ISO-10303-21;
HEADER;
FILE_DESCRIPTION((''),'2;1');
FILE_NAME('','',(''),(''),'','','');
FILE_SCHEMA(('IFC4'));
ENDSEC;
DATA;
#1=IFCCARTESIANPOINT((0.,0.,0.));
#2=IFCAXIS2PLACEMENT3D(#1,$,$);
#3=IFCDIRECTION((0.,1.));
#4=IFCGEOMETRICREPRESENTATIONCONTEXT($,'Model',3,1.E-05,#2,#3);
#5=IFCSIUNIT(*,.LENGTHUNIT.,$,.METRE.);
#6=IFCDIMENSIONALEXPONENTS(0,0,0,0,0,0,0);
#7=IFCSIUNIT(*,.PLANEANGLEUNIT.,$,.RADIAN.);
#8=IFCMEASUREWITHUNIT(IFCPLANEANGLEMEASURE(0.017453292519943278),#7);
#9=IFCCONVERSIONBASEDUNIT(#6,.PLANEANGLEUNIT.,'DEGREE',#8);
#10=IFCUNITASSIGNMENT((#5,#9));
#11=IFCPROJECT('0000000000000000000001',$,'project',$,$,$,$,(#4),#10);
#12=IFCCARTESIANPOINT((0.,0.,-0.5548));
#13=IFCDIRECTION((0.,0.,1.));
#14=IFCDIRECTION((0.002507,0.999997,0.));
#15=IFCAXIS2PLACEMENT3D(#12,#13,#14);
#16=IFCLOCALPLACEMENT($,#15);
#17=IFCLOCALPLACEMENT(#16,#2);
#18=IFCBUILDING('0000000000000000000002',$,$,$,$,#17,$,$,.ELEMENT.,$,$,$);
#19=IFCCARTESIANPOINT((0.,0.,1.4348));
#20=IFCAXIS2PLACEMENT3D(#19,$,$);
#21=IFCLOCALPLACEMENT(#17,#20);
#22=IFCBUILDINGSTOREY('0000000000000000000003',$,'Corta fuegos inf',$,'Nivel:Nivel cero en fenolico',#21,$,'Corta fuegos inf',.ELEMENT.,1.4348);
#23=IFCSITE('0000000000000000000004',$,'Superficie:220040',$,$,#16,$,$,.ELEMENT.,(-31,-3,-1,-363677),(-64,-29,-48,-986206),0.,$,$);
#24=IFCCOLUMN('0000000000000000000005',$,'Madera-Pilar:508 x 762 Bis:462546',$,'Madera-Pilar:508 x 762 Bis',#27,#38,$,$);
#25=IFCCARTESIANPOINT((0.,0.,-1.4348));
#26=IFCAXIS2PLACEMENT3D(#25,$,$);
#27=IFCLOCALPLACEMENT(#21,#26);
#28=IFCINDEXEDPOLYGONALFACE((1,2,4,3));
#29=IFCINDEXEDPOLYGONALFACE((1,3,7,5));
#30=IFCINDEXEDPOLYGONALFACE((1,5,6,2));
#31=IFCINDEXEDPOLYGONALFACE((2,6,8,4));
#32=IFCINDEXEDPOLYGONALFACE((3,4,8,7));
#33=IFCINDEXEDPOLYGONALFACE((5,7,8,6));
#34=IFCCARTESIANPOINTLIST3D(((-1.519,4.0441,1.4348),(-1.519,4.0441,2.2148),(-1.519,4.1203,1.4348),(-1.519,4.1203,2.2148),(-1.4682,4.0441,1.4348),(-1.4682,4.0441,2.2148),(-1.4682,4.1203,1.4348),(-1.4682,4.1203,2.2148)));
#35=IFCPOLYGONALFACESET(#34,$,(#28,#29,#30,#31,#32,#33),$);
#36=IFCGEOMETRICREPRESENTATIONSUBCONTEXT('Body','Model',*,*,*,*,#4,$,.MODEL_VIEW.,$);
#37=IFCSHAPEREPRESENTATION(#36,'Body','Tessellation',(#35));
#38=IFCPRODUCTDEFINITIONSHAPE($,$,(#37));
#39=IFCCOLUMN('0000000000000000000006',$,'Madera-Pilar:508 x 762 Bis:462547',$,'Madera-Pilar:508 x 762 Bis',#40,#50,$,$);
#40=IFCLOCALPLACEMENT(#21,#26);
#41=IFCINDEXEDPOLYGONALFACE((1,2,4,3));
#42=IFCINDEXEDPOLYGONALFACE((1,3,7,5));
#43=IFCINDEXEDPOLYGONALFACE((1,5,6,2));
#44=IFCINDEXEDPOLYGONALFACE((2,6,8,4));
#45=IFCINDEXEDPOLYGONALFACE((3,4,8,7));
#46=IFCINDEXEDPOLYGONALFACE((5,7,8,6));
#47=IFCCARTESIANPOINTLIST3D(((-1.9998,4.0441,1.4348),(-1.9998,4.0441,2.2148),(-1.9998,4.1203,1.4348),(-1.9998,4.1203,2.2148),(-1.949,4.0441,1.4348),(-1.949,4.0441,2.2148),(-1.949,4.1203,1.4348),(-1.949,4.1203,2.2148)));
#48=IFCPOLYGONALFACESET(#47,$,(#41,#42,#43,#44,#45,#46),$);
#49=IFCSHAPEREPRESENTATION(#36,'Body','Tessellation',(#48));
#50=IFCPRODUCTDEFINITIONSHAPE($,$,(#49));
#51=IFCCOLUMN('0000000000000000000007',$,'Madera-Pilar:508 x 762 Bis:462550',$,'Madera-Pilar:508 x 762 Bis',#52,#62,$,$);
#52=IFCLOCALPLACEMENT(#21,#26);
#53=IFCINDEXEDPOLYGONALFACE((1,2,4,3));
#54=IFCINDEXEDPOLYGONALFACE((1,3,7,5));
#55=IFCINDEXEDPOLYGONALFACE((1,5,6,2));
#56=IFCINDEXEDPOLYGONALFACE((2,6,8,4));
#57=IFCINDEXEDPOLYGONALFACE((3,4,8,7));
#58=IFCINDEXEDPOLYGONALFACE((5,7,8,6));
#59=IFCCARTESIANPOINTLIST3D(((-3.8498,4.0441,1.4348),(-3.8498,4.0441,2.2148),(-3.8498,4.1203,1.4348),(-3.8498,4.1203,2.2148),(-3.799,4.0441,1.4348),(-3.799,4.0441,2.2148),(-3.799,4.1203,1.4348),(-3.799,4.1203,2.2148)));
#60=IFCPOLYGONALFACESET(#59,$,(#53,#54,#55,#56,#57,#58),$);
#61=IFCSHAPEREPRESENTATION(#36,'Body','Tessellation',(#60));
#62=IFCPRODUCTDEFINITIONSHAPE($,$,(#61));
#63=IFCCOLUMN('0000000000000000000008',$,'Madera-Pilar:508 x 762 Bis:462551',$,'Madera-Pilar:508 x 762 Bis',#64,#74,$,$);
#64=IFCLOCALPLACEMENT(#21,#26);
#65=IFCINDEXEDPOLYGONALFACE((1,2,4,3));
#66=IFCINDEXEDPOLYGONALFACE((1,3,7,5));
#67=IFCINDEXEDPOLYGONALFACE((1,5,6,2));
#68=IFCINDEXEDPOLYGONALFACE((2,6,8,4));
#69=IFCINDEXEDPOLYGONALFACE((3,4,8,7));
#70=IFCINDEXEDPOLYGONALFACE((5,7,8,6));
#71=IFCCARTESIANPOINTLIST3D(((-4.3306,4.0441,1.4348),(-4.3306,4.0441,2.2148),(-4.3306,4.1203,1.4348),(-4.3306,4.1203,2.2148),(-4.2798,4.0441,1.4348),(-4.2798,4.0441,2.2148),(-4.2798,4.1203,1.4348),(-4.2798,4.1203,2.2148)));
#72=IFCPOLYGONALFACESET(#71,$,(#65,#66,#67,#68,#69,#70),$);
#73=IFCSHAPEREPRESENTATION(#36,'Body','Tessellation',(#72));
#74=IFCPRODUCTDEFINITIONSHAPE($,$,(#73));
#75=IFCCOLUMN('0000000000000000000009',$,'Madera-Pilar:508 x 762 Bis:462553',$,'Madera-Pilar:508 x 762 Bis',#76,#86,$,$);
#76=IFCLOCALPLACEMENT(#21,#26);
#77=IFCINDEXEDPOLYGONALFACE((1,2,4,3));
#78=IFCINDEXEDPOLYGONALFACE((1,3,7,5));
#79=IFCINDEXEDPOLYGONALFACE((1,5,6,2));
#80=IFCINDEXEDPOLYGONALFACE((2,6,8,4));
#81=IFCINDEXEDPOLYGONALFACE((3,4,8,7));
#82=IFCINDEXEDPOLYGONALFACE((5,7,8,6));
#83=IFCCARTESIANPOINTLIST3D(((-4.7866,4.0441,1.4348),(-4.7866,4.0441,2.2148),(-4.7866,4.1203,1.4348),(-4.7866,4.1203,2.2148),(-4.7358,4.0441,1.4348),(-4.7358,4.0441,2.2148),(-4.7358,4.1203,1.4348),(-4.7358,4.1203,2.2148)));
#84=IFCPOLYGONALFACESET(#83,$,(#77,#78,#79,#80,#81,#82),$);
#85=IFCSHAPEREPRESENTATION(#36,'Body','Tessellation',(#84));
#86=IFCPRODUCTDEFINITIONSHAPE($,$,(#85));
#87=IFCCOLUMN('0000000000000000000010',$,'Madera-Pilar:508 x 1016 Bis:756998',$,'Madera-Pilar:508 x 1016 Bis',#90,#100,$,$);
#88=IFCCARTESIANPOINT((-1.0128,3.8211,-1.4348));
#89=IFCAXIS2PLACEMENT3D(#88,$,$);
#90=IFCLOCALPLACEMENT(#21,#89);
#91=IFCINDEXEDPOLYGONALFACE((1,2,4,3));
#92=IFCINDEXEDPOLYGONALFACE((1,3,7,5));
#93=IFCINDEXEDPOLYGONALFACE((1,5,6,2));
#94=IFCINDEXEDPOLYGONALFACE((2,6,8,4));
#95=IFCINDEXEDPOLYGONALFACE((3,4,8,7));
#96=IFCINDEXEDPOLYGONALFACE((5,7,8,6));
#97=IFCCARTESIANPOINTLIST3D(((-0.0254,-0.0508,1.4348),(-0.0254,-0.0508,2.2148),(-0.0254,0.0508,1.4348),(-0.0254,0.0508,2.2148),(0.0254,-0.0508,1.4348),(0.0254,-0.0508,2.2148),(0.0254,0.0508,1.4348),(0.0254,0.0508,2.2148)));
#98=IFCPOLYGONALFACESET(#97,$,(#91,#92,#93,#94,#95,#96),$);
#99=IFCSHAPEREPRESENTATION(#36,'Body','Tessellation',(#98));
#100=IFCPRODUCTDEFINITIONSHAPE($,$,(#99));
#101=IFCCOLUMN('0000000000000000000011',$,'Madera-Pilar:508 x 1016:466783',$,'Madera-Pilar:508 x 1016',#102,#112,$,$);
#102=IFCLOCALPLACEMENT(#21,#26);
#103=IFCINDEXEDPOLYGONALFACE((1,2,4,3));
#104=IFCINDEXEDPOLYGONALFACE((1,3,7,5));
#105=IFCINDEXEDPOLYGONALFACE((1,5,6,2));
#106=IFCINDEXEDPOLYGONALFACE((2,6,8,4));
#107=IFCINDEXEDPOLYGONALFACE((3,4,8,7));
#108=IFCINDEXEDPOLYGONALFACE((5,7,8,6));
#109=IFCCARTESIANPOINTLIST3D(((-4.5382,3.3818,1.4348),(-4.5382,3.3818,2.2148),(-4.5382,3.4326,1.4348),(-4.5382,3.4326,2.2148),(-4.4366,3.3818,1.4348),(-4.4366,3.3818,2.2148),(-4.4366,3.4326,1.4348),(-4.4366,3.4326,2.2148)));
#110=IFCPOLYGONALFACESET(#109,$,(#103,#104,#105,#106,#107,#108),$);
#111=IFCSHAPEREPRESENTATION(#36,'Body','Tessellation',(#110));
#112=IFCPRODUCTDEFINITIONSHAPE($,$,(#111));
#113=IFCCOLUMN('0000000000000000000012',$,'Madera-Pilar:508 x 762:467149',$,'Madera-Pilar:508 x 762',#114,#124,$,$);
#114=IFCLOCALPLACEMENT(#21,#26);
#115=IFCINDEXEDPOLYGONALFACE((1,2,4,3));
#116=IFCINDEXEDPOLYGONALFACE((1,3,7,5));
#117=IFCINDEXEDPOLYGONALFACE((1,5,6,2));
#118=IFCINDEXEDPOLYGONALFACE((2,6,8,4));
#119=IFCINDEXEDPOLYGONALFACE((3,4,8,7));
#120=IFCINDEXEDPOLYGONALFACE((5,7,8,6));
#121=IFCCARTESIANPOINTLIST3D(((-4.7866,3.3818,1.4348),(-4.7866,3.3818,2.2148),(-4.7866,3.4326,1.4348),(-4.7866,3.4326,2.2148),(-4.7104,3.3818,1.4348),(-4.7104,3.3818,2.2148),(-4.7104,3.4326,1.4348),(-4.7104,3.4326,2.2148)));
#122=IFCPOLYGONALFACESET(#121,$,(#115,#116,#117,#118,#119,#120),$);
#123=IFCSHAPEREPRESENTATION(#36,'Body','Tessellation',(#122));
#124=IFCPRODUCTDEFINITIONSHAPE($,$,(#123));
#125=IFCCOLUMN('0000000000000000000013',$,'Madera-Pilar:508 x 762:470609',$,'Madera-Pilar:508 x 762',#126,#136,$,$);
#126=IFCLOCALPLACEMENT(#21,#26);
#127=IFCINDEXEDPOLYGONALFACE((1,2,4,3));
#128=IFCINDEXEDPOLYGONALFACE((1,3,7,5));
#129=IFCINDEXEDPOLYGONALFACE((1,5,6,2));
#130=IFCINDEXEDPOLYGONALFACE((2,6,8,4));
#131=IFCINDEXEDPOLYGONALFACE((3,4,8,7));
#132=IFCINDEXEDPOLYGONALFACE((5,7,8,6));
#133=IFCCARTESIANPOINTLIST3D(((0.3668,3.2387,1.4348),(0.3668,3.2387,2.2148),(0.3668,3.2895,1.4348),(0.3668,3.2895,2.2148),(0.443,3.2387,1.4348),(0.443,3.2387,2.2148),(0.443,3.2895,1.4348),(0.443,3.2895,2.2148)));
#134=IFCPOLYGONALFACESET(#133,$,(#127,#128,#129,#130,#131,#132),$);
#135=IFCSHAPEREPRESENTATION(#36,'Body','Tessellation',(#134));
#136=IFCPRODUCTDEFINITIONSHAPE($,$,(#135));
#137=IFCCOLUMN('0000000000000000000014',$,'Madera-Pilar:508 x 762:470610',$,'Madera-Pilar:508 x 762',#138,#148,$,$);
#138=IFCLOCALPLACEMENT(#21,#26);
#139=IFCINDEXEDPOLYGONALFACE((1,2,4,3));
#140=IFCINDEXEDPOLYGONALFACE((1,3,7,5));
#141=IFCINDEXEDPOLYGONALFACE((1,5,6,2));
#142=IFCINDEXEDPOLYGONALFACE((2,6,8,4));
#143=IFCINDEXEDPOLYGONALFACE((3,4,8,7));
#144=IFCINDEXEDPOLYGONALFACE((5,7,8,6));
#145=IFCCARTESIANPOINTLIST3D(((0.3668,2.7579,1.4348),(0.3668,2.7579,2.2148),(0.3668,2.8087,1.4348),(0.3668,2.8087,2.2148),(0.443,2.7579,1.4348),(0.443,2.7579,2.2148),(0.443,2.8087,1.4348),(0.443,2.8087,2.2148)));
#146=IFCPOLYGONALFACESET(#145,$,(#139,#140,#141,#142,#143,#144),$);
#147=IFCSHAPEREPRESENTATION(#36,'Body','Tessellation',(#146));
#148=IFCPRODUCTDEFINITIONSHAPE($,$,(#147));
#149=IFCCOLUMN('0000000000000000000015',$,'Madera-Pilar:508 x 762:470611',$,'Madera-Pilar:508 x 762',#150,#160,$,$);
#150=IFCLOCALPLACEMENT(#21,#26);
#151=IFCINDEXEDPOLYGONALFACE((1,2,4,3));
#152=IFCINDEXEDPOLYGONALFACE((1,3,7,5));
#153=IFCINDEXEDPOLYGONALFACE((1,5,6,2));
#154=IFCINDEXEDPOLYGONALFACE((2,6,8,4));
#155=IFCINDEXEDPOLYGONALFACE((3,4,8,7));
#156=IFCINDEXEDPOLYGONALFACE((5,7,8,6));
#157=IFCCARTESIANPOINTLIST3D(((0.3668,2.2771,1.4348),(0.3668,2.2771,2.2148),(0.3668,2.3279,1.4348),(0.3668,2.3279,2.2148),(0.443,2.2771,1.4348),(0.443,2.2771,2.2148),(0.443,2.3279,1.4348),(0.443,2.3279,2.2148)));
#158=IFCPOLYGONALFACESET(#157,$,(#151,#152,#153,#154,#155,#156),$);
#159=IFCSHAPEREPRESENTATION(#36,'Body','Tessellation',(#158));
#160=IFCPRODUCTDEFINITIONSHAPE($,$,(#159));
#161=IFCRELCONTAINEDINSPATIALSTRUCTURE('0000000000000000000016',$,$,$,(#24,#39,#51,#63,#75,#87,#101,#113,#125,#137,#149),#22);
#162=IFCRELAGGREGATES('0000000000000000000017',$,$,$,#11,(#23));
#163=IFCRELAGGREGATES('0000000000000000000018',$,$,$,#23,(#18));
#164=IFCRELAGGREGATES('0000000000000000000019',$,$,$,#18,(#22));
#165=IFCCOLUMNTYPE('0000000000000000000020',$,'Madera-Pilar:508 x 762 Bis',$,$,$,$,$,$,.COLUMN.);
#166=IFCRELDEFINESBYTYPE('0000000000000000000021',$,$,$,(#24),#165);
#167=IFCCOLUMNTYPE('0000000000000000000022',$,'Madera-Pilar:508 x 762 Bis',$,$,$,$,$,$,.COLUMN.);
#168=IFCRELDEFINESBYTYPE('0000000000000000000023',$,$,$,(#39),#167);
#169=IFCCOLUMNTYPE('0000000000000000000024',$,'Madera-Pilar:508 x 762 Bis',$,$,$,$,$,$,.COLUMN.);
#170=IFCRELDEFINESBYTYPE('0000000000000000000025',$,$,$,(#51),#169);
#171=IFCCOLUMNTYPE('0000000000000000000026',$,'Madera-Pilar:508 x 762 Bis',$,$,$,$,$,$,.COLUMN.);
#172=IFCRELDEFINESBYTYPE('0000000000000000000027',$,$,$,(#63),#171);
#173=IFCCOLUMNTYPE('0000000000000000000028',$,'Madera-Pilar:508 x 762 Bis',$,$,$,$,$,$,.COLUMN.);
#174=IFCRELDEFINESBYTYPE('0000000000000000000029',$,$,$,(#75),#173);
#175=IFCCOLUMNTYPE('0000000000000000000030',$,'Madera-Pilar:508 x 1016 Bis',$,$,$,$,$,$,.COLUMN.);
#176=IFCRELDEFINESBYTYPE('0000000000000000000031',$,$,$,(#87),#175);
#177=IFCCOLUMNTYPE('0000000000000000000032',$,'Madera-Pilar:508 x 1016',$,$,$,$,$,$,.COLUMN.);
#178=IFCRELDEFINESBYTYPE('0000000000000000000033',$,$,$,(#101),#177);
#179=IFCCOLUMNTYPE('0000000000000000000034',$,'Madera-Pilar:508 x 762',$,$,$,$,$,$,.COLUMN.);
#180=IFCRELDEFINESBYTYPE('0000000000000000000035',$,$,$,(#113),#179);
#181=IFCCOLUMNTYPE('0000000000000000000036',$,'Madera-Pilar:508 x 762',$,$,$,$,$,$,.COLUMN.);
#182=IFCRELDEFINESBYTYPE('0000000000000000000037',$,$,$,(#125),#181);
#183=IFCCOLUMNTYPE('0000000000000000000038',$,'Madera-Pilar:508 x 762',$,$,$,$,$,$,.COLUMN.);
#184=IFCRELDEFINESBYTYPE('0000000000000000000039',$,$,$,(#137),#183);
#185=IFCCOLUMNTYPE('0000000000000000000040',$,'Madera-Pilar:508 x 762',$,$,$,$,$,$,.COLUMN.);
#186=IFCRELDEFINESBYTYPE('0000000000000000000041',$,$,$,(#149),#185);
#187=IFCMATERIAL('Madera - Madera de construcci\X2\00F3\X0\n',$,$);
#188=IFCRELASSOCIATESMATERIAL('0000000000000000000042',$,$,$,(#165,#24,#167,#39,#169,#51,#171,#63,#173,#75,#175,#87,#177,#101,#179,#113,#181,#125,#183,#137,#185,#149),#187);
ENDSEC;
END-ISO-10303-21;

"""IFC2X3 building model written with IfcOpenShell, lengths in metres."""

from ifc_helpers import new_model, entity, si_unit, converted_unit, direction, frame, frame_2d, origin, origin_2d_with_axis, place, context, subcontext, project, spatial, rectangle, extrude, source, transform, mapped, material, type_object, type_shapes, element, save


model = new_model("IFC2X3")

# Units and contexts
model_context = context("Model", 3, precision=1e-05, world=origin(), true_north=direction((0.0, 1.0)))
body_context = subcontext(model_context, "Body", "Model", "MODEL_VIEW")
ifc_project = project(units=[si_unit("LENGTHUNIT", "METRE"), converted_unit("PLANEANGLEUNIT", "DEGREE", entity("IfcPlaneAngleMeasure", 0.017453292519943278), si_unit("PLANEANGLEUNIT", "RADIAN"), dimensions=[0, 0, 0, 0, 0, 0, 0])], contexts=[model_context])

# Site, building, storey
site_placement = place(None, frame((0.0, 0.0, -0.5548), z_axis=(0.0, 0.0, 1.0), x_axis=(0.002507, 0.999997, 0.0)))
site = spatial("IfcSite", under=ifc_project, at=site_placement, Name="Superficie:220040", CompositionType="ELEMENT", RefLatitude=(-31, -3, -1, -363677), RefLongitude=(-64, -29, -48, -986206), RefElevation=0.0)
building_placement = place(site_placement, origin())
building = spatial("IfcBuilding", under=site, at=building_placement, CompositionType="ELEMENT")
storey_placement = place(building_placement, frame((0.0, 0.0, 1.4348)))
storey = spatial("IfcBuildingStorey", under=building, at=storey_placement, Name="Corta fuegos inf", ObjectType="Nivel:Nivel cero en fenolico", LongName="Corta fuegos inf", CompositionType="ELEMENT", Elevation=1.4348)

# Columns
ifc_material_1 = material(Name="Madera - Madera de construcción")
column_type_1 = type_object("IfcColumnType", Name="Madera-Pilar:508 x 762 Bis", PredefinedType="COLUMN", material=ifc_material_1)
shared_shape_1 = source(origin(), body_context, "Body", "SweptSolid", [
    extrude(rectangle(XDim=0.0508, YDim=0.0762, at=frame_2d((0.0, 0.0), x_axis=(1.0, 0.0))), frame((-1.4936, 4.0822, 1.4348), z_axis=(0.0, 0.0, 1.0), x_axis=(-1.0, 0.0, 0.0)), (0.0, 0.0, 1.0), 0.78),
])
type_shapes(column_type_1, [shared_shape_1])
column_1_placement = place(storey_placement, frame((0.0, 0.0, -1.4348)))
element("IfcColumn", 1, at=column_1_placement, inside=storey, type_object=column_type_1, material=ifc_material_1, Name="Madera-Pilar:508 x 762 Bis:462546", ObjectType="Madera-Pilar:508 x 762 Bis", context=body_context, shape_type="MappedRepresentation", body=[
    mapped(shared_shape_1, transform((0.0, 0.0, 0.0), scale=1.0)),
])
column_type_2 = type_object("IfcColumnType", Name="Madera-Pilar:508 x 762 Bis", PredefinedType="COLUMN", material=ifc_material_1)
shared_shape_2 = source(origin(), body_context, "Body", "SweptSolid", [
    extrude(rectangle(XDim=0.0508, YDim=0.0762, at=frame_2d((0.0, 0.0), x_axis=(1.0, 0.0))), frame((-1.9744, 4.0822, 1.4348), z_axis=(0.0, 0.0, 1.0), x_axis=(-1.0, 0.0, 0.0)), (0.0, 0.0, 1.0), 0.78),
])
type_shapes(column_type_2, [shared_shape_2])
column_2_placement = place(storey_placement, frame((0.0, 0.0, -1.4348)))
element("IfcColumn", 2, at=column_2_placement, inside=storey, type_object=column_type_2, material=ifc_material_1, Name="Madera-Pilar:508 x 762 Bis:462547", ObjectType="Madera-Pilar:508 x 762 Bis", context=body_context, shape_type="MappedRepresentation", body=[
    mapped(shared_shape_2, transform((0.0, 0.0, 0.0), scale=1.0)),
])
column_type_3 = type_object("IfcColumnType", Name="Madera-Pilar:508 x 762 Bis", PredefinedType="COLUMN", material=ifc_material_1)
shared_shape_3 = source(origin(), body_context, "Body", "SweptSolid", [
    extrude(rectangle(XDim=0.0508, YDim=0.0762, at=frame_2d((0.0, 0.0), x_axis=(1.0, 0.0))), frame((-3.8244, 4.0822, 1.4348), z_axis=(0.0, 0.0, 1.0), x_axis=(-1.0, 0.0, 0.0)), (0.0, 0.0, 1.0), 0.78),
])
type_shapes(column_type_3, [shared_shape_3])
column_3_placement = place(storey_placement, frame((0.0, 0.0, -1.4348)))
element("IfcColumn", 3, at=column_3_placement, inside=storey, type_object=column_type_3, material=ifc_material_1, Name="Madera-Pilar:508 x 762 Bis:462550", ObjectType="Madera-Pilar:508 x 762 Bis", context=body_context, shape_type="MappedRepresentation", body=[
    mapped(shared_shape_3, transform((0.0, 0.0, 0.0), scale=1.0)),
])
column_type_4 = type_object("IfcColumnType", Name="Madera-Pilar:508 x 762 Bis", PredefinedType="COLUMN", material=ifc_material_1)
shared_shape_4 = source(origin(), body_context, "Body", "SweptSolid", [
    extrude(rectangle(XDim=0.0508, YDim=0.0762, at=frame_2d((0.0, 0.0), x_axis=(1.0, 0.0))), frame((-4.3052, 4.0822, 1.4348), z_axis=(0.0, 0.0, 1.0), x_axis=(-1.0, 0.0, 0.0)), (0.0, 0.0, 1.0), 0.78),
])
type_shapes(column_type_4, [shared_shape_4])
column_4_placement = place(storey_placement, frame((0.0, 0.0, -1.4348)))
element("IfcColumn", 4, at=column_4_placement, inside=storey, type_object=column_type_4, material=ifc_material_1, Name="Madera-Pilar:508 x 762 Bis:462551", ObjectType="Madera-Pilar:508 x 762 Bis", context=body_context, shape_type="MappedRepresentation", body=[
    mapped(shared_shape_4, transform((0.0, 0.0, 0.0), scale=1.0)),
])
column_type_5 = type_object("IfcColumnType", Name="Madera-Pilar:508 x 762 Bis", PredefinedType="COLUMN", material=ifc_material_1)
shared_shape_5 = source(origin(), body_context, "Body", "SweptSolid", [
    extrude(rectangle(XDim=0.0508, YDim=0.0762, at=frame_2d((0.0, 0.0), x_axis=(1.0, 0.0))), frame((-4.7612, 4.0822, 1.4348), z_axis=(0.0, 0.0, 1.0), x_axis=(-1.0, 0.0, 0.0)), (0.0, 0.0, 1.0), 0.78),
])
type_shapes(column_type_5, [shared_shape_5])
column_5_placement = place(storey_placement, frame((0.0, 0.0, -1.4348)))
element("IfcColumn", 5, at=column_5_placement, inside=storey, type_object=column_type_5, material=ifc_material_1, Name="Madera-Pilar:508 x 762 Bis:462553", ObjectType="Madera-Pilar:508 x 762 Bis", context=body_context, shape_type="MappedRepresentation", body=[
    mapped(shared_shape_5, transform((0.0, 0.0, 0.0), scale=1.0)),
])
column_type_6 = type_object("IfcColumnType", Name="Madera-Pilar:508 x 1016 Bis", PredefinedType="COLUMN", material=ifc_material_1)
shared_shape_6 = source(origin(), body_context, "Body", "SweptSolid", [
    extrude(rectangle(XDim=0.0508, YDim=0.1016, at=origin_2d_with_axis()), frame((0.0, 0.0, 1.4348), z_axis=(0.0, 0.0, 1.0), x_axis=(-1.0, 0.0, 0.0)), (0.0, 0.0, 1.0), 0.78),
])
type_shapes(column_type_6, [shared_shape_6])
column_6_placement = place(storey_placement, frame((-1.0128, 3.8211, -1.4348)))
element("IfcColumn", 6, at=column_6_placement, inside=storey, type_object=column_type_6, material=ifc_material_1, Name="Madera-Pilar:508 x 1016 Bis:756998", ObjectType="Madera-Pilar:508 x 1016 Bis", context=body_context, shape_type="MappedRepresentation", body=[
    mapped(shared_shape_6, transform((0.0, 0.0, 0.0), scale=1.0)),
])
column_type_7 = type_object("IfcColumnType", Name="Madera-Pilar:508 x 1016", PredefinedType="COLUMN", material=ifc_material_1)
shared_shape_7 = source(origin(), body_context, "Body", "SweptSolid", [
    extrude(rectangle(XDim=0.1016, YDim=0.0508, at=frame_2d((0.0, 0.0), x_axis=(1.0, 0.0))), frame((-4.4874, 3.4072, 1.4348), z_axis=(0.0, 0.0, 1.0), x_axis=(-1.0, 0.0, 0.0)), (0.0, 0.0, 1.0), 0.78),
])
type_shapes(column_type_7, [shared_shape_7])
column_7_placement = place(storey_placement, frame((0.0, 0.0, -1.4348)))
element("IfcColumn", 7, at=column_7_placement, inside=storey, type_object=column_type_7, material=ifc_material_1, Name="Madera-Pilar:508 x 1016:466783", ObjectType="Madera-Pilar:508 x 1016", context=body_context, shape_type="MappedRepresentation", body=[
    mapped(shared_shape_7, transform((0.0, 0.0, 0.0), scale=1.0)),
])
column_type_8 = type_object("IfcColumnType", Name="Madera-Pilar:508 x 762", PredefinedType="COLUMN", material=ifc_material_1)
shared_shape_8 = source(origin(), body_context, "Body", "SweptSolid", [
    extrude(rectangle(XDim=0.0762, YDim=0.0508, at=origin_2d_with_axis()), frame((-4.7485, 3.4072, 1.4348), z_axis=(0.0, 0.0, 1.0), x_axis=(-1.0, 0.0, 0.0)), (0.0, 0.0, 1.0), 0.78),
])
type_shapes(column_type_8, [shared_shape_8])
column_8_placement = place(storey_placement, frame((0.0, 0.0, -1.4348)))
element("IfcColumn", 8, at=column_8_placement, inside=storey, type_object=column_type_8, material=ifc_material_1, Name="Madera-Pilar:508 x 762:467149", ObjectType="Madera-Pilar:508 x 762", context=body_context, shape_type="MappedRepresentation", body=[
    mapped(shared_shape_8, transform((0.0, 0.0, 0.0), scale=1.0)),
])
column_type_9 = type_object("IfcColumnType", Name="Madera-Pilar:508 x 762", PredefinedType="COLUMN", material=ifc_material_1)
shared_shape_9 = source(origin(), body_context, "Body", "SweptSolid", [
    extrude(rectangle(XDim=0.0762, YDim=0.0508, at=origin_2d_with_axis()), frame((0.4049, 3.2641, 1.4348), z_axis=(0.0, 0.0, 1.0), x_axis=(-1.0, 0.0, 0.0)), (0.0, 0.0, 1.0), 0.78),
])
type_shapes(column_type_9, [shared_shape_9])
column_9_placement = place(storey_placement, frame((0.0, 0.0, -1.4348)))
element("IfcColumn", 9, at=column_9_placement, inside=storey, type_object=column_type_9, material=ifc_material_1, Name="Madera-Pilar:508 x 762:470609", ObjectType="Madera-Pilar:508 x 762", context=body_context, shape_type="MappedRepresentation", body=[
    mapped(shared_shape_9, transform((0.0, 0.0, 0.0), scale=1.0)),
])
column_type_10 = type_object("IfcColumnType", Name="Madera-Pilar:508 x 762", PredefinedType="COLUMN", material=ifc_material_1)
shared_shape_10 = source(origin(), body_context, "Body", "SweptSolid", [
    extrude(rectangle(XDim=0.0762, YDim=0.0508, at=origin_2d_with_axis()), frame((0.4049, 2.7833, 1.4348), z_axis=(0.0, 0.0, 1.0), x_axis=(-1.0, 0.0, 0.0)), (0.0, 0.0, 1.0), 0.78),
])
type_shapes(column_type_10, [shared_shape_10])
column_10_placement = place(storey_placement, frame((0.0, 0.0, -1.4348)))
element("IfcColumn", 10, at=column_10_placement, inside=storey, type_object=column_type_10, material=ifc_material_1, Name="Madera-Pilar:508 x 762:470610", ObjectType="Madera-Pilar:508 x 762", context=body_context, shape_type="MappedRepresentation", body=[
    mapped(shared_shape_10, transform((0.0, 0.0, 0.0), scale=1.0)),
])
column_type_11 = type_object("IfcColumnType", Name="Madera-Pilar:508 x 762", PredefinedType="COLUMN", material=ifc_material_1)
shared_shape_11 = source(origin(), body_context, "Body", "SweptSolid", [
    extrude(rectangle(XDim=0.0762, YDim=0.0508, at=origin_2d_with_axis()), frame((0.4049, 2.3025, 1.4348), z_axis=(0.0, 0.0, 1.0), x_axis=(-1.0, 0.0, 0.0)), (0.0, 0.0, 1.0), 0.78),
])
type_shapes(column_type_11, [shared_shape_11])
column_11_placement = place(storey_placement, frame((0.0, 0.0, -1.4348)))
element("IfcColumn", 11, at=column_11_placement, inside=storey, type_object=column_type_11, material=ifc_material_1, Name="Madera-Pilar:508 x 762:470611", ObjectType="Madera-Pilar:508 x 762", context=body_context, shape_type="MappedRepresentation", body=[
    mapped(shared_shape_11, transform((0.0, 0.0, 0.0), scale=1.0)),
])

save(model, "model.ifc")
